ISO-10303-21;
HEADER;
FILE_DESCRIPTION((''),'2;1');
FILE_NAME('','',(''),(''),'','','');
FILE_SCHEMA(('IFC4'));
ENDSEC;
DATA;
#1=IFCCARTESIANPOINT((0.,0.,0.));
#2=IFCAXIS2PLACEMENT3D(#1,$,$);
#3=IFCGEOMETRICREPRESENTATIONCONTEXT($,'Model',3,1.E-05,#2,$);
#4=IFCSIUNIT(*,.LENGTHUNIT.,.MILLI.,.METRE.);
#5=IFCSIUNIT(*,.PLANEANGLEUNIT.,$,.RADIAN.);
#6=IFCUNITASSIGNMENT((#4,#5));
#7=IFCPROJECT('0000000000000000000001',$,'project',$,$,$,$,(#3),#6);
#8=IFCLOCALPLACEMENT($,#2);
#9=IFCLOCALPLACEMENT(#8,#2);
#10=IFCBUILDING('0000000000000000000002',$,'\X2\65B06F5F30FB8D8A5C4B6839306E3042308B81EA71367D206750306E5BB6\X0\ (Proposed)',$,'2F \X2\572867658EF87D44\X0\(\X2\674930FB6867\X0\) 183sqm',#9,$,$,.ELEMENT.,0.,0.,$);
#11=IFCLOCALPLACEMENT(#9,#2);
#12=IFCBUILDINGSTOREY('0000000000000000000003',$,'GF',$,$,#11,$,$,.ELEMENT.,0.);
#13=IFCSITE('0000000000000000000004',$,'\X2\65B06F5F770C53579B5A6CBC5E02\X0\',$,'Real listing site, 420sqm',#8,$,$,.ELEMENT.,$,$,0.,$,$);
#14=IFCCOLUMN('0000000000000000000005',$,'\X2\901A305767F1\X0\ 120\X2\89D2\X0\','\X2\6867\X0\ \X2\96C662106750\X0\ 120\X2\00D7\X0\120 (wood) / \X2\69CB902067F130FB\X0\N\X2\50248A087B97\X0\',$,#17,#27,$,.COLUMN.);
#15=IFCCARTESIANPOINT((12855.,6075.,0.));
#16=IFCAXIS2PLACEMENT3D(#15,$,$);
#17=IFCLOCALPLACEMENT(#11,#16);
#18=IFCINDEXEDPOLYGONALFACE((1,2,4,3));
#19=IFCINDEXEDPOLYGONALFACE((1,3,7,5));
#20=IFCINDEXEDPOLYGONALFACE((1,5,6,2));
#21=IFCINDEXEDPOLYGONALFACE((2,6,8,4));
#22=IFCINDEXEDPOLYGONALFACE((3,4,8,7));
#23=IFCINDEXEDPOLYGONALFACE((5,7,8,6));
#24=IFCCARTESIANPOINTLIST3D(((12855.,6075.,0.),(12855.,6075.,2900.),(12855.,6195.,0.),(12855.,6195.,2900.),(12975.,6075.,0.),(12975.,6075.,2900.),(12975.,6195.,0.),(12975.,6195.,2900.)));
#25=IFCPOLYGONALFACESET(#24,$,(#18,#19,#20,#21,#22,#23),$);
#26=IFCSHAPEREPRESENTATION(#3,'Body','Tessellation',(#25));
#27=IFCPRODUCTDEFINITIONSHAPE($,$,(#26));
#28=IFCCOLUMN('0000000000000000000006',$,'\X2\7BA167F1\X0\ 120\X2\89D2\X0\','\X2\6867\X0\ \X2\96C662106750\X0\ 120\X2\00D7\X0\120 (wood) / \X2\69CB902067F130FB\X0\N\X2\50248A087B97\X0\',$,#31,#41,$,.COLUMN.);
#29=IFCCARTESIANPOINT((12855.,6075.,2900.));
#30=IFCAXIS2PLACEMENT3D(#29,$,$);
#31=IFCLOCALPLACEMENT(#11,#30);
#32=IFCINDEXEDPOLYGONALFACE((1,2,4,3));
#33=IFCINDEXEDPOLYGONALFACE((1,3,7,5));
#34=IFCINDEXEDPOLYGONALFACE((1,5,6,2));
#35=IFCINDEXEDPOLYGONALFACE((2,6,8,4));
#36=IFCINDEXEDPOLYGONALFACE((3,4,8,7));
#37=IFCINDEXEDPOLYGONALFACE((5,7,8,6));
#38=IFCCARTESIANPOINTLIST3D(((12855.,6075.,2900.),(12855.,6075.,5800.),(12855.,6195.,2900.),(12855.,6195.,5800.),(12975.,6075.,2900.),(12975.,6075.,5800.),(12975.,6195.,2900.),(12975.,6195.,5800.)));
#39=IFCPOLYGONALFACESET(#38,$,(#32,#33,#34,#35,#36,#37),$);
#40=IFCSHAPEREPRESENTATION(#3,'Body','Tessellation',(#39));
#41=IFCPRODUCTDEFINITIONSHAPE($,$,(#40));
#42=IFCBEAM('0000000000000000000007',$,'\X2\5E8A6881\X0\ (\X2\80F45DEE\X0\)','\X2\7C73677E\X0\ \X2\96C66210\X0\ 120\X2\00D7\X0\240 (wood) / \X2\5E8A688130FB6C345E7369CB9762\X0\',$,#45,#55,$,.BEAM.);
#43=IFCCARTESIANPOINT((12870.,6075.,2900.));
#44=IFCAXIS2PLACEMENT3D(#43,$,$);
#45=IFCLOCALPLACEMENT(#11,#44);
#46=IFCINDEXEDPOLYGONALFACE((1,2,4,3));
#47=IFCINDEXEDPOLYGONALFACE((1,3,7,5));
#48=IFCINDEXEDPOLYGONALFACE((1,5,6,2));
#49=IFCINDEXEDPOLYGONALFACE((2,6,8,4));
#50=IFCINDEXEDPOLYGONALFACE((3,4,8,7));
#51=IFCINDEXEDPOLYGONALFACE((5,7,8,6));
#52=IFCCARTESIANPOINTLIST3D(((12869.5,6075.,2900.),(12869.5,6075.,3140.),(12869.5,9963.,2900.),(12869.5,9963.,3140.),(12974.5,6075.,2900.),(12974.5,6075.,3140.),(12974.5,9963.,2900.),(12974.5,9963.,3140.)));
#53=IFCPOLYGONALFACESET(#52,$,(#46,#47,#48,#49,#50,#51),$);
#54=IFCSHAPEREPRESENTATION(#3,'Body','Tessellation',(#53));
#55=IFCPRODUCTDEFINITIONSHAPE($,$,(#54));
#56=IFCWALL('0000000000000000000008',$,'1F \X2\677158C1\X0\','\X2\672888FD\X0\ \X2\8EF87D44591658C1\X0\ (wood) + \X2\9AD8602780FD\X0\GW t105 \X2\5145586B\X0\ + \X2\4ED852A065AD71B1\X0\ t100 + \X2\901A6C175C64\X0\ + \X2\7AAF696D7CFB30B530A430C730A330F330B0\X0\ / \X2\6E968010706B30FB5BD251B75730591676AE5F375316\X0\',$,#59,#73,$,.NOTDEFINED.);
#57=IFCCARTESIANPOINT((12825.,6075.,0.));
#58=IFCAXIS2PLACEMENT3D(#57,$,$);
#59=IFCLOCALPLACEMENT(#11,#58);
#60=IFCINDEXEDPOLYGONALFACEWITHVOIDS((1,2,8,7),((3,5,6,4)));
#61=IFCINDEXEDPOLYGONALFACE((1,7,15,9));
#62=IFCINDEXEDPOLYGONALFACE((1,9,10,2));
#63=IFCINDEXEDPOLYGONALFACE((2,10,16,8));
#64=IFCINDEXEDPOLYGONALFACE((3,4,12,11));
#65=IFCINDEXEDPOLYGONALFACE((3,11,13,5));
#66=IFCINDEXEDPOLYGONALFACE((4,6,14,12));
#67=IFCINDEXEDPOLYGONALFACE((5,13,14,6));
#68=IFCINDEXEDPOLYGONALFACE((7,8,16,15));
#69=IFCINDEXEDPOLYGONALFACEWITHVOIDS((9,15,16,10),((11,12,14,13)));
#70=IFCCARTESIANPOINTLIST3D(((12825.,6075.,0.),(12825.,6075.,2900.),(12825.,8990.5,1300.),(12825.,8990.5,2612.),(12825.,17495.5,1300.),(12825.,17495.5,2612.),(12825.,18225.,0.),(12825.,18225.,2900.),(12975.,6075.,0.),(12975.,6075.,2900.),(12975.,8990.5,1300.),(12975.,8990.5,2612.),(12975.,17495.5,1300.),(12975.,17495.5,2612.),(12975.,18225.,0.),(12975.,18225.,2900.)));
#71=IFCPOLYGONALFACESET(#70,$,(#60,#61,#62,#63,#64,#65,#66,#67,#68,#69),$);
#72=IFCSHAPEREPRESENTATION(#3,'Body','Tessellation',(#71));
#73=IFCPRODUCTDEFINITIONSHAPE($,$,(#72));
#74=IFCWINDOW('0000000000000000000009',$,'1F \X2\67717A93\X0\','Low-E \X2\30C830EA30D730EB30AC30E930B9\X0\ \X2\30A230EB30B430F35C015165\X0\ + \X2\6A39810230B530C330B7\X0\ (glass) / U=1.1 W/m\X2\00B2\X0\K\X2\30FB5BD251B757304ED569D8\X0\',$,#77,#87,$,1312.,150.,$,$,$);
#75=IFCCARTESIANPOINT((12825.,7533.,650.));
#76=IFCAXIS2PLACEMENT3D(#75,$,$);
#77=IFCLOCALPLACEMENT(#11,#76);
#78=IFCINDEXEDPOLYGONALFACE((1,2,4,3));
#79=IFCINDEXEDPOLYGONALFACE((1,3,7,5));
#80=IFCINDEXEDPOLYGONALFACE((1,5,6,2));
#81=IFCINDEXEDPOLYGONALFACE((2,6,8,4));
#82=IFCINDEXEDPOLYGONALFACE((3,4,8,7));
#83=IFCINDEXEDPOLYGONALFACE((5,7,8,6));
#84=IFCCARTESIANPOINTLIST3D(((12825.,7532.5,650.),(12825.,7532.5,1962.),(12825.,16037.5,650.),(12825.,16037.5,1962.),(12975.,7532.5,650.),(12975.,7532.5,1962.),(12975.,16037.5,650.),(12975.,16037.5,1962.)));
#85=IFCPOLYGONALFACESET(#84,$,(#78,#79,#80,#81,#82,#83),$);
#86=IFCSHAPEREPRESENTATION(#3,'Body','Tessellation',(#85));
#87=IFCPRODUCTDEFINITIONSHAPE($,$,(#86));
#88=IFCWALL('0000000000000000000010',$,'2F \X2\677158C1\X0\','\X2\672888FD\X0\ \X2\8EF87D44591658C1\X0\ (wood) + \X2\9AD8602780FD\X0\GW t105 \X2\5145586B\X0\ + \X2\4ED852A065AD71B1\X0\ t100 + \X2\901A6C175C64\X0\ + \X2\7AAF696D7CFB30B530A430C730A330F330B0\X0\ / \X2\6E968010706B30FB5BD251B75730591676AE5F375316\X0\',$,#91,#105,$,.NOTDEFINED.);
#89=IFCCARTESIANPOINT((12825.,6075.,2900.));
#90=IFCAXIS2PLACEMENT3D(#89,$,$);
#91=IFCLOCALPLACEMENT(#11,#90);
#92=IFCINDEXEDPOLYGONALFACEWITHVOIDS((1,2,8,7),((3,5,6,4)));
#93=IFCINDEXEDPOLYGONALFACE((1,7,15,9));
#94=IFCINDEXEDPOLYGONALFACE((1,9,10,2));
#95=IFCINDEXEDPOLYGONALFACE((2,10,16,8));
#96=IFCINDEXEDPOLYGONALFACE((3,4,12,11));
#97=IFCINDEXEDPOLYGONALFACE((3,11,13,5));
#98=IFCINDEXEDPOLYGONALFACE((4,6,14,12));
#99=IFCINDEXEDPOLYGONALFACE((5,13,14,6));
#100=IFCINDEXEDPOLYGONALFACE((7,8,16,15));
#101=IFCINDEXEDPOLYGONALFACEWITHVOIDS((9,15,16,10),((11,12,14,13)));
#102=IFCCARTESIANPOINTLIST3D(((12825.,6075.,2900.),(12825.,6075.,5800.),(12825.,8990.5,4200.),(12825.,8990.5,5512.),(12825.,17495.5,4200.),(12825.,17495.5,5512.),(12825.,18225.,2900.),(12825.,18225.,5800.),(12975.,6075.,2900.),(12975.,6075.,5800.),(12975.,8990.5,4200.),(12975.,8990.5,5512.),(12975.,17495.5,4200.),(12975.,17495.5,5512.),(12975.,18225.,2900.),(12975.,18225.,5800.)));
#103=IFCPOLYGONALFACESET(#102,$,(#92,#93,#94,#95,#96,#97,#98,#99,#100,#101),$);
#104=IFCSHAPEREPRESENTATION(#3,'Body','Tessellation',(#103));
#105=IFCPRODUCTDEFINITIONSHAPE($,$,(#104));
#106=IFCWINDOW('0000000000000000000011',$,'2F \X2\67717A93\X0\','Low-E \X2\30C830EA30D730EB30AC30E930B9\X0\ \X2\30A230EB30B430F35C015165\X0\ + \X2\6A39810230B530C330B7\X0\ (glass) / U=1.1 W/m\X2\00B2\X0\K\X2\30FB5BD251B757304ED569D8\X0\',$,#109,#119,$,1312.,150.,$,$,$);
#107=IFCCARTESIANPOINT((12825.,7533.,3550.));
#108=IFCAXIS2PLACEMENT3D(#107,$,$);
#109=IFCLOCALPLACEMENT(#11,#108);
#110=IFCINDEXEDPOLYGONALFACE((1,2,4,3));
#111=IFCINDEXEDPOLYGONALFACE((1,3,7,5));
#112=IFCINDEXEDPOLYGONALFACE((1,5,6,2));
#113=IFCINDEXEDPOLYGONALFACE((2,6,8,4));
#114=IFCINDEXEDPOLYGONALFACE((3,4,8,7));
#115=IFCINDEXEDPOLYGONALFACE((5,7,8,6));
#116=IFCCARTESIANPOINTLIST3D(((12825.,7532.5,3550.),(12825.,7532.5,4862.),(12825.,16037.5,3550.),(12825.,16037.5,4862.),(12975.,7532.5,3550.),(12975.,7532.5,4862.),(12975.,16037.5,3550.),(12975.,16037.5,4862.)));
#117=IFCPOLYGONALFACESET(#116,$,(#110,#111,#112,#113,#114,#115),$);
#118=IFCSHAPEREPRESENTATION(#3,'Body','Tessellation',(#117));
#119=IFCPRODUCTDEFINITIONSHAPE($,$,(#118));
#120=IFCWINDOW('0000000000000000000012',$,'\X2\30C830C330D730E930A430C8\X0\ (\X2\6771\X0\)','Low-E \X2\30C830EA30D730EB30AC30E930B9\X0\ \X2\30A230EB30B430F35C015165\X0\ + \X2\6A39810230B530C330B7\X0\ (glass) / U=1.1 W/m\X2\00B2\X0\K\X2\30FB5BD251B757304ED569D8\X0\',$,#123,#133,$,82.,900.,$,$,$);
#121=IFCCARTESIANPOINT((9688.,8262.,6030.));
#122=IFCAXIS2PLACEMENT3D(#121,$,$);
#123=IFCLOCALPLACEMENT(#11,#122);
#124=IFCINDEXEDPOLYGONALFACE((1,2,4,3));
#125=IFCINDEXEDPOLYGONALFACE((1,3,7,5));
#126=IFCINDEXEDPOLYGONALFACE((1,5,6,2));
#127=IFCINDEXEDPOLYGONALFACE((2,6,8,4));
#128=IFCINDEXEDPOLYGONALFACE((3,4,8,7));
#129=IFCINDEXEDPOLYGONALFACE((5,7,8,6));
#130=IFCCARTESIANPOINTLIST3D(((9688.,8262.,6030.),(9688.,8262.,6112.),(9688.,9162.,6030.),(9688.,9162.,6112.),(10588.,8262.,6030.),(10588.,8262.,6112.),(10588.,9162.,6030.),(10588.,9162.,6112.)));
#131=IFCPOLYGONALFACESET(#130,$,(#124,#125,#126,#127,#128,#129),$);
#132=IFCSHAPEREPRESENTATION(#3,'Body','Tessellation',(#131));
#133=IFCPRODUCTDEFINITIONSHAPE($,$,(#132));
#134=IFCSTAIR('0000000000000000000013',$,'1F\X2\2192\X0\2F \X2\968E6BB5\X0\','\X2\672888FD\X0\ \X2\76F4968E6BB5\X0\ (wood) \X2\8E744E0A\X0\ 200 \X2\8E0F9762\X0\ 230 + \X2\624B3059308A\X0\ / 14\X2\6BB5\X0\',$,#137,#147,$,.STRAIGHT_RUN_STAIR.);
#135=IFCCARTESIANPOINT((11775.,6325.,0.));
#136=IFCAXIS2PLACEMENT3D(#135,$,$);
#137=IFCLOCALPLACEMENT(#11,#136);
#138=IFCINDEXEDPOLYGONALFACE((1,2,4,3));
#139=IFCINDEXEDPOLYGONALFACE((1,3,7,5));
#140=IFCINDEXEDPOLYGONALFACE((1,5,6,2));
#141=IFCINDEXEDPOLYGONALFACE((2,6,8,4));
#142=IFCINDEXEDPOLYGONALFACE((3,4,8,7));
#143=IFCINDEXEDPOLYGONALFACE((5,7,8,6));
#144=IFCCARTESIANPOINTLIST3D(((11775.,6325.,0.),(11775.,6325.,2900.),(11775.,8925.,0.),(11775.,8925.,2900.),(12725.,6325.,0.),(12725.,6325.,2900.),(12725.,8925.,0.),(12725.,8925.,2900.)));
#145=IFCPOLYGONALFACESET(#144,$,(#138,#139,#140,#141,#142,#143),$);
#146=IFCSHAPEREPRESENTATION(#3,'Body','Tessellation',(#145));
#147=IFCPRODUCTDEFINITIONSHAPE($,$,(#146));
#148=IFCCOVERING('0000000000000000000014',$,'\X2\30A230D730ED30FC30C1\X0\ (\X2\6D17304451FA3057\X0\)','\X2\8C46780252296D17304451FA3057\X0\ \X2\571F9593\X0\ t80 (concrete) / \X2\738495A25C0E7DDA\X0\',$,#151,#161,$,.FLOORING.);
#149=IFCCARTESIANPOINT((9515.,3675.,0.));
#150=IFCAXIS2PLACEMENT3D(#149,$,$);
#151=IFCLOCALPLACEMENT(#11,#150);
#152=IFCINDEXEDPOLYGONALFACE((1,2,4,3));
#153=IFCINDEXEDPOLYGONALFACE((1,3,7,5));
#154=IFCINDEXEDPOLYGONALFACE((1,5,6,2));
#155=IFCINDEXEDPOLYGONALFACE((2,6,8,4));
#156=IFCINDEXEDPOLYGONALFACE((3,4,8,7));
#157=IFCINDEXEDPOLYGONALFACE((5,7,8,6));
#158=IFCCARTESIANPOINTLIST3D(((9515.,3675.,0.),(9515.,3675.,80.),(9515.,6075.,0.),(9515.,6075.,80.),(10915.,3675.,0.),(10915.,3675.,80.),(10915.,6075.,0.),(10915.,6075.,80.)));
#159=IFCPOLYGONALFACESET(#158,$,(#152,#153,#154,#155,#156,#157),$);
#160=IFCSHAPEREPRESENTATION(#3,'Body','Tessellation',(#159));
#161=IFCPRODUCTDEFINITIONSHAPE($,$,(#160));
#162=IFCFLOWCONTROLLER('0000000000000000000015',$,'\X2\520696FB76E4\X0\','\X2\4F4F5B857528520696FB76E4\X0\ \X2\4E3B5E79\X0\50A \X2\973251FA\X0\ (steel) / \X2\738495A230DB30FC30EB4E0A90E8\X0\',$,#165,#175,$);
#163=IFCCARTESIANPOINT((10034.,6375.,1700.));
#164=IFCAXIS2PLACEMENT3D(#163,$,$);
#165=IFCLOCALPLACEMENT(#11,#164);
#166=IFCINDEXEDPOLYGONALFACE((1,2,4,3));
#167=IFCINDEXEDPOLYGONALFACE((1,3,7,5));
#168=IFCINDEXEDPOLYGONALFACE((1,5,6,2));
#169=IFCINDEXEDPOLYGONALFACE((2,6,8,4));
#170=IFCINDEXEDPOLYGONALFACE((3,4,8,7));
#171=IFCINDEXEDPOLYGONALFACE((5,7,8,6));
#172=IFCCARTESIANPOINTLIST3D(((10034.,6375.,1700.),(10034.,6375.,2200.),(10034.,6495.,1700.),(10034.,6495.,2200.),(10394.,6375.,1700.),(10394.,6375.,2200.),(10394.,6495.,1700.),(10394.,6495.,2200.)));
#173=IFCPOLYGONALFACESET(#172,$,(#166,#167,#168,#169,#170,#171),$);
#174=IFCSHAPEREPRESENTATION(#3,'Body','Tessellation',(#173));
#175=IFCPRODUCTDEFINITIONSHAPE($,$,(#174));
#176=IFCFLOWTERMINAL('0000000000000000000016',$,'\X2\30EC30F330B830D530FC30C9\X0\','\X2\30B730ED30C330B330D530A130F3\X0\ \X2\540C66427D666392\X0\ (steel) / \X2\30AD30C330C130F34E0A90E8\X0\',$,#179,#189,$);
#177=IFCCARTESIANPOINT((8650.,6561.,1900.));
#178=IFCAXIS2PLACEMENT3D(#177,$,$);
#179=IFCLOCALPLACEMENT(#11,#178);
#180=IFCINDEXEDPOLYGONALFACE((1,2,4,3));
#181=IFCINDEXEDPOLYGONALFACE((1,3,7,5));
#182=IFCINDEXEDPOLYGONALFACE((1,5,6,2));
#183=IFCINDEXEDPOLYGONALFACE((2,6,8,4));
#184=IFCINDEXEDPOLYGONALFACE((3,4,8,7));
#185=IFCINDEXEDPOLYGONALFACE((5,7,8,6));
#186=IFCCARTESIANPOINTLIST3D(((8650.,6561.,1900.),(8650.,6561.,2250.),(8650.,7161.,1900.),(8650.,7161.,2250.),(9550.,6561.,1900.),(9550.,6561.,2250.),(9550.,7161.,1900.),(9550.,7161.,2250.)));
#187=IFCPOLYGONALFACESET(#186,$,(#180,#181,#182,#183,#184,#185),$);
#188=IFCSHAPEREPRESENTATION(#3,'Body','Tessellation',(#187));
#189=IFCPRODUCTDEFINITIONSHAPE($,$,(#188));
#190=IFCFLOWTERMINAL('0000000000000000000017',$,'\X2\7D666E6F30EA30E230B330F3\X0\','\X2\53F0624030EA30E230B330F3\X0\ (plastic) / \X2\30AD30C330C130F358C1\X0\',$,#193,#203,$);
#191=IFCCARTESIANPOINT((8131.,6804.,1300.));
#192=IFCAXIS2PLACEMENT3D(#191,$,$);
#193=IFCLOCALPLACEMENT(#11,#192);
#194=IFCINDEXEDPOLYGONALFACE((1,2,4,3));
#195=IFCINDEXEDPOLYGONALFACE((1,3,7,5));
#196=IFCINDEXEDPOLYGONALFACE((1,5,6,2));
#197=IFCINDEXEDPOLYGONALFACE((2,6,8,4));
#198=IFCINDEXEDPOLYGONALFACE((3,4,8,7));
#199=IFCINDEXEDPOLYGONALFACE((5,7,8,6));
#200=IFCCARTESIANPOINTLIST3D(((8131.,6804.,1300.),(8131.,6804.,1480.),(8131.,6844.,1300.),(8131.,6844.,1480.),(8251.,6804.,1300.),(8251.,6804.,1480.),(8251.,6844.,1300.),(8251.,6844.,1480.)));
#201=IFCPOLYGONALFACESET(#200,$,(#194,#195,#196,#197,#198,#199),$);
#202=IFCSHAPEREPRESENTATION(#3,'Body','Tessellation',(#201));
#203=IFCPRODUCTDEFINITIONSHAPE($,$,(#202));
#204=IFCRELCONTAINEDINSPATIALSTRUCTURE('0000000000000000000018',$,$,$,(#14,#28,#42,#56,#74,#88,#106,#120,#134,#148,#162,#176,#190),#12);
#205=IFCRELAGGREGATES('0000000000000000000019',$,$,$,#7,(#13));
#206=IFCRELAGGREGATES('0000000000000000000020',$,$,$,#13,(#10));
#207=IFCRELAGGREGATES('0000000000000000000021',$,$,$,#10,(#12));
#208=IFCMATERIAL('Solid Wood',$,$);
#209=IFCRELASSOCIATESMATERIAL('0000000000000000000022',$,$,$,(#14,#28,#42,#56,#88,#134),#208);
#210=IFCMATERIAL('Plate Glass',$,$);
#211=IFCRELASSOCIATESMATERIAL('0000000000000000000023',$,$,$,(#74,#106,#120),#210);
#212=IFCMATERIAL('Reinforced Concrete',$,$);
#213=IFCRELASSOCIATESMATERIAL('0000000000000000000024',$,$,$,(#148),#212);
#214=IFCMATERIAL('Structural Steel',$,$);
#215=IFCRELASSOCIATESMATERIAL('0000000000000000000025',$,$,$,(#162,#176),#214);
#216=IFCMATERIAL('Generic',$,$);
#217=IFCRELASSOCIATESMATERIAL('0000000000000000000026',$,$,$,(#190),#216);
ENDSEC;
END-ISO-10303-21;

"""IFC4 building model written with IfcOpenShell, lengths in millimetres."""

from ifc_helpers import new_model, si_unit, frame, frame_2d, origin, place, context, project, spatial, rectangle, extrude, material, element, fill, save


model = new_model("IFC4")

# Units and contexts
model_context = context("Model", 3, precision=1e-05, world=origin())
ifc_project = project(units=[si_unit("LENGTHUNIT", "METRE", prefix="MILLI"), si_unit("PLANEANGLEUNIT", "RADIAN")], contexts=[model_context])

# Site, building, storey
site_placement = place(None, origin())
site = spatial("IfcSite", under=ifc_project, at=site_placement, Name="新潟県南魚沼市", ObjectType="Real listing site, 420sqm", CompositionType="ELEMENT", RefElevation=0.0)
building_placement = place(site_placement, origin())
building = spatial("IfcBuilding", under=site, at=building_placement, Name="新潟・越屋根のある自然素材の家 (Proposed)", ObjectType="2F 在来軸組(杉・桧) 183sqm", CompositionType="ELEMENT", ElevationOfRefHeight=0.0, ElevationOfTerrain=0.0)
storey_placement = place(building_placement, origin())
storey = spatial("IfcBuildingStorey", under=building, at=storey_placement, Name="GF", CompositionType="ELEMENT", Elevation=0.0)

# Columns
ifc_material_1 = material(Name="Solid Wood")
column_1_placement = place(storey_placement, frame((12855.0, 6075.0, 0.0)))
element("IfcColumn", 1, at=column_1_placement, inside=storey, material=ifc_material_1, Name="通し柱 120角", Description="桧 集成材 120×120 (wood) / 構造柱・N値計算", PredefinedType="COLUMN", context=model_context, shape_type="SweptSolid", body=[
    extrude(rectangle(XDim=120.0, YDim=120.0, at=frame_2d((60.0, 60.0))), frame((12855.0, 6075.0, 0.0)), (0.0, 0.0, 1.0), 2900.0),
])
column_2_placement = place(storey_placement, frame((12855.0, 6075.0, 2900.0)))
element("IfcColumn", 2, at=column_2_placement, inside=storey, material=ifc_material_1, Name="管柱 120角", Description="桧 集成材 120×120 (wood) / 構造柱・N値計算", PredefinedType="COLUMN", context=model_context, shape_type="SweptSolid", body=[
    extrude(rectangle(XDim=120.0, YDim=120.0, at=frame_2d((60.0, 60.0))), frame((12855.0, 6075.0, 2900.0)), (0.0, 0.0, 1.0), 2900.0),
])

# Beam
beam_1_placement = place(storey_placement, frame((12870.0, 6075.0, 2900.0)))
element("IfcBeam", 3, at=beam_1_placement, inside=storey, material=ifc_material_1, Name="床梁 (胴差)", Description="米松 集成 120×240 (wood) / 床梁・水平構面", PredefinedType="BEAM", context=model_context, shape_type="SweptSolid", body=[
    extrude(rectangle(XDim=105.0, YDim=3888.0, at=frame_2d((52.0, 1944.0))), frame((12870.0, 6075.0, 2900.0)), (0.0, 0.0, 1.0), 240.0),
])

# Wall, opening, window
wall_1_placement = place(storey_placement, frame((12825.0, 6075.0, 0.0)))
wall_1 = element("IfcWall", 4, at=wall_1_placement, inside=storey, material=ifc_material_1, Name="1F 東壁", Description="木製 軸組外壁 (wood) + 高性能GW t105 充填 + 付加断熱 t100 + 通気層 + 窯業系サイディング / 準耐火・寒冷地外皮強化", PredefinedType="NOTDEFINED", context=model_context, shape_type="SweptSolid", body=[
    extrude(rectangle(XDim=150.0, YDim=12150.0, at=frame_2d((75.0, 6075.0))), frame((12825.0, 6075.0, 0.0)), (0.0, 0.0, 1.0), 2900.0),
])
opening_1_placement = place(storey_placement, frame((12825.0, 7533.0, 650.0)))
opening_1 = element("IfcOpeningElement", 5, at=opening_1_placement, cuts=wall_1, PredefinedType="NOTDEFINED", context=model_context, shape_type="SweptSolid", body=[
    extrude(rectangle(XDim=150.0, YDim=8505.0, at=frame_2d((75.0, 4252.0))), frame((12825.0, 7533.0, 650.0)), (0.0, 0.0, 1.0), 1312.0),
])
ifc_material_2 = material(Name="Plate Glass")
window_1_placement = place(storey_placement, frame((12825.0, 7533.0, 650.0)))
window_1 = element("IfcWindow", 6, at=window_1_placement, inside=storey, material=ifc_material_2, Name="1F 東窓", Description="Low-E トリプルガラス アルゴン封入 + 樹脂サッシ (glass) / U=1.1 W/m²K・寒冷地仕様", OverallHeight=1312.0, OverallWidth=150.0, context=model_context, shape_type="SweptSolid", body=[
    extrude(rectangle(XDim=150.0, YDim=8505.0, at=frame_2d((75.0, 4252.0))), frame((12825.0, 7533.0, 650.0)), (0.0, 0.0, 1.0), 1312.0),
])
fill(opening_1, window_1)

# Wall, opening, window
wall_2_placement = place(storey_placement, frame((12825.0, 6075.0, 2900.0)))
wall_2 = element("IfcWall", 7, at=wall_2_placement, inside=storey, material=ifc_material_1, Name="2F 東壁", Description="木製 軸組外壁 (wood) + 高性能GW t105 充填 + 付加断熱 t100 + 通気層 + 窯業系サイディング / 準耐火・寒冷地外皮強化", PredefinedType="NOTDEFINED", context=model_context, shape_type="SweptSolid", body=[
    extrude(rectangle(XDim=150.0, YDim=12150.0, at=frame_2d((75.0, 6075.0))), frame((12825.0, 6075.0, 2900.0)), (0.0, 0.0, 1.0), 2900.0),
])
opening_2_placement = place(storey_placement, frame((12825.0, 7533.0, 3550.0)))
opening_2 = element("IfcOpeningElement", 8, at=opening_2_placement, cuts=wall_2, PredefinedType="NOTDEFINED", context=model_context, shape_type="SweptSolid", body=[
    extrude(rectangle(XDim=150.0, YDim=8505.0, at=frame_2d((75.0, 4252.0))), frame((12825.0, 7533.0, 3550.0)), (0.0, 0.0, 1.0), 1312.0),
])
window_2_placement = place(storey_placement, frame((12825.0, 7533.0, 3550.0)))
window_2 = element("IfcWindow", 9, at=window_2_placement, inside=storey, material=ifc_material_2, Name="2F 東窓", Description="Low-E トリプルガラス アルゴン封入 + 樹脂サッシ (glass) / U=1.1 W/m²K・寒冷地仕様", OverallHeight=1312.0, OverallWidth=150.0, context=model_context, shape_type="SweptSolid", body=[
    extrude(rectangle(XDim=150.0, YDim=8505.0, at=frame_2d((75.0, 4252.0))), frame((12825.0, 7533.0, 3550.0)), (0.0, 0.0, 1.0), 1312.0),
])
fill(opening_2, window_2)

# Window
window_3_placement = place(storey_placement, frame((9688.0, 8262.0, 6030.0)))
element("IfcWindow", 10, at=window_3_placement, inside=storey, material=ifc_material_2, Name="トップライト (東)", Description="Low-E トリプルガラス アルゴン封入 + 樹脂サッシ (glass) / U=1.1 W/m²K・寒冷地仕様", OverallHeight=82.0, OverallWidth=900.0, context=model_context, shape_type="SweptSolid", body=[
    extrude(rectangle(XDim=900.0, YDim=900.0, at=frame_2d((450.0, 450.0))), frame((9688.0, 8262.0, 6030.0)), (0.0, 0.0, 1.0), 82.0),
])

# Stair
stair_placement = place(storey_placement, frame((11775.0, 6325.0, 0.0)))
element("IfcStair", 11, at=stair_placement, inside=storey, material=ifc_material_1, Name="1F→2F 階段", Description="木製 直階段 (wood) 蹴上 200 踏面 230 + 手すり / 14段", PredefinedType="STRAIGHT_RUN_STAIR", context=model_context, shape_type="SweptSolid", body=[
    extrude(rectangle(XDim=950.0, YDim=2600.0, at=frame_2d((475.0, 1300.0))), frame((11775.0, 6325.0, 0.0)), (0.0, 0.0, 1.0), 2900.0),
])

# Covering
ifc_material_3 = material(Name="Reinforced Concrete")
covering_placement = place(storey_placement, frame((9515.0, 3675.0, 0.0)))
element("IfcCovering", 12, at=covering_placement, inside=storey, material=ifc_material_3, Name="アプローチ (洗い出し)", Description="豆砂利洗い出し 土間 t80 (concrete) / 玄関導線", PredefinedType="FLOORING", context=model_context, shape_type="SweptSolid", body=[
    extrude(rectangle(XDim=1400.0, YDim=2400.0, at=frame_2d((700.0, 1200.0))), frame((9515.0, 3675.0, 0.0)), (0.0, 0.0, 1.0), 80.0),
])

# Flow controller
ifc_material_4 = material(Name="Structural Steel")
flow_controller_placement = place(storey_placement, frame((10034.0, 6375.0, 1700.0)))
element("IfcFlowController", 13, at=flow_controller_placement, inside=storey, material=ifc_material_4, Name="分電盤", Description="住宅用分電盤 主幹50A 露出 (steel) / 玄関ホール上部", context=model_context, shape_type="SweptSolid", body=[
    extrude(rectangle(XDim=360.0, YDim=120.0, at=frame_2d((180.0, 60.0))), frame((10034.0, 6375.0, 1700.0)), (0.0, 0.0, 1.0), 500.0),
])

# Flow terminals
flow_terminal_1_placement = place(storey_placement, frame((8650.0, 6561.0, 1900.0)))
element("IfcFlowTerminal", 14, at=flow_terminal_1_placement, inside=storey, material=ifc_material_4, Name="レンジフード", Description="シロッコファン 同時給排 (steel) / キッチン上部", context=model_context, shape_type="SweptSolid", body=[
    extrude(rectangle(XDim=900.0, YDim=600.0, at=frame_2d((450.0, 300.0))), frame((8650.0, 6561.0, 1900.0)), (0.0, 0.0, 1.0), 350.0),
])
ifc_material_5 = material(Name="Generic")
flow_terminal_2_placement = place(storey_placement, frame((8131.0, 6804.0, 1300.0)))
element("IfcFlowTerminal", 15, at=flow_terminal_2_placement, inside=storey, material=ifc_material_5, Name="給湯リモコン", Description="台所リモコン (plastic) / キッチン壁", context=model_context, shape_type="SweptSolid", body=[
    extrude(rectangle(XDim=120.0, YDim=40.0, at=frame_2d((60.0, 20.0))), frame((8131.0, 6804.0, 1300.0)), (0.0, 0.0, 1.0), 180.0),
])

save(model, "model.ifc")
